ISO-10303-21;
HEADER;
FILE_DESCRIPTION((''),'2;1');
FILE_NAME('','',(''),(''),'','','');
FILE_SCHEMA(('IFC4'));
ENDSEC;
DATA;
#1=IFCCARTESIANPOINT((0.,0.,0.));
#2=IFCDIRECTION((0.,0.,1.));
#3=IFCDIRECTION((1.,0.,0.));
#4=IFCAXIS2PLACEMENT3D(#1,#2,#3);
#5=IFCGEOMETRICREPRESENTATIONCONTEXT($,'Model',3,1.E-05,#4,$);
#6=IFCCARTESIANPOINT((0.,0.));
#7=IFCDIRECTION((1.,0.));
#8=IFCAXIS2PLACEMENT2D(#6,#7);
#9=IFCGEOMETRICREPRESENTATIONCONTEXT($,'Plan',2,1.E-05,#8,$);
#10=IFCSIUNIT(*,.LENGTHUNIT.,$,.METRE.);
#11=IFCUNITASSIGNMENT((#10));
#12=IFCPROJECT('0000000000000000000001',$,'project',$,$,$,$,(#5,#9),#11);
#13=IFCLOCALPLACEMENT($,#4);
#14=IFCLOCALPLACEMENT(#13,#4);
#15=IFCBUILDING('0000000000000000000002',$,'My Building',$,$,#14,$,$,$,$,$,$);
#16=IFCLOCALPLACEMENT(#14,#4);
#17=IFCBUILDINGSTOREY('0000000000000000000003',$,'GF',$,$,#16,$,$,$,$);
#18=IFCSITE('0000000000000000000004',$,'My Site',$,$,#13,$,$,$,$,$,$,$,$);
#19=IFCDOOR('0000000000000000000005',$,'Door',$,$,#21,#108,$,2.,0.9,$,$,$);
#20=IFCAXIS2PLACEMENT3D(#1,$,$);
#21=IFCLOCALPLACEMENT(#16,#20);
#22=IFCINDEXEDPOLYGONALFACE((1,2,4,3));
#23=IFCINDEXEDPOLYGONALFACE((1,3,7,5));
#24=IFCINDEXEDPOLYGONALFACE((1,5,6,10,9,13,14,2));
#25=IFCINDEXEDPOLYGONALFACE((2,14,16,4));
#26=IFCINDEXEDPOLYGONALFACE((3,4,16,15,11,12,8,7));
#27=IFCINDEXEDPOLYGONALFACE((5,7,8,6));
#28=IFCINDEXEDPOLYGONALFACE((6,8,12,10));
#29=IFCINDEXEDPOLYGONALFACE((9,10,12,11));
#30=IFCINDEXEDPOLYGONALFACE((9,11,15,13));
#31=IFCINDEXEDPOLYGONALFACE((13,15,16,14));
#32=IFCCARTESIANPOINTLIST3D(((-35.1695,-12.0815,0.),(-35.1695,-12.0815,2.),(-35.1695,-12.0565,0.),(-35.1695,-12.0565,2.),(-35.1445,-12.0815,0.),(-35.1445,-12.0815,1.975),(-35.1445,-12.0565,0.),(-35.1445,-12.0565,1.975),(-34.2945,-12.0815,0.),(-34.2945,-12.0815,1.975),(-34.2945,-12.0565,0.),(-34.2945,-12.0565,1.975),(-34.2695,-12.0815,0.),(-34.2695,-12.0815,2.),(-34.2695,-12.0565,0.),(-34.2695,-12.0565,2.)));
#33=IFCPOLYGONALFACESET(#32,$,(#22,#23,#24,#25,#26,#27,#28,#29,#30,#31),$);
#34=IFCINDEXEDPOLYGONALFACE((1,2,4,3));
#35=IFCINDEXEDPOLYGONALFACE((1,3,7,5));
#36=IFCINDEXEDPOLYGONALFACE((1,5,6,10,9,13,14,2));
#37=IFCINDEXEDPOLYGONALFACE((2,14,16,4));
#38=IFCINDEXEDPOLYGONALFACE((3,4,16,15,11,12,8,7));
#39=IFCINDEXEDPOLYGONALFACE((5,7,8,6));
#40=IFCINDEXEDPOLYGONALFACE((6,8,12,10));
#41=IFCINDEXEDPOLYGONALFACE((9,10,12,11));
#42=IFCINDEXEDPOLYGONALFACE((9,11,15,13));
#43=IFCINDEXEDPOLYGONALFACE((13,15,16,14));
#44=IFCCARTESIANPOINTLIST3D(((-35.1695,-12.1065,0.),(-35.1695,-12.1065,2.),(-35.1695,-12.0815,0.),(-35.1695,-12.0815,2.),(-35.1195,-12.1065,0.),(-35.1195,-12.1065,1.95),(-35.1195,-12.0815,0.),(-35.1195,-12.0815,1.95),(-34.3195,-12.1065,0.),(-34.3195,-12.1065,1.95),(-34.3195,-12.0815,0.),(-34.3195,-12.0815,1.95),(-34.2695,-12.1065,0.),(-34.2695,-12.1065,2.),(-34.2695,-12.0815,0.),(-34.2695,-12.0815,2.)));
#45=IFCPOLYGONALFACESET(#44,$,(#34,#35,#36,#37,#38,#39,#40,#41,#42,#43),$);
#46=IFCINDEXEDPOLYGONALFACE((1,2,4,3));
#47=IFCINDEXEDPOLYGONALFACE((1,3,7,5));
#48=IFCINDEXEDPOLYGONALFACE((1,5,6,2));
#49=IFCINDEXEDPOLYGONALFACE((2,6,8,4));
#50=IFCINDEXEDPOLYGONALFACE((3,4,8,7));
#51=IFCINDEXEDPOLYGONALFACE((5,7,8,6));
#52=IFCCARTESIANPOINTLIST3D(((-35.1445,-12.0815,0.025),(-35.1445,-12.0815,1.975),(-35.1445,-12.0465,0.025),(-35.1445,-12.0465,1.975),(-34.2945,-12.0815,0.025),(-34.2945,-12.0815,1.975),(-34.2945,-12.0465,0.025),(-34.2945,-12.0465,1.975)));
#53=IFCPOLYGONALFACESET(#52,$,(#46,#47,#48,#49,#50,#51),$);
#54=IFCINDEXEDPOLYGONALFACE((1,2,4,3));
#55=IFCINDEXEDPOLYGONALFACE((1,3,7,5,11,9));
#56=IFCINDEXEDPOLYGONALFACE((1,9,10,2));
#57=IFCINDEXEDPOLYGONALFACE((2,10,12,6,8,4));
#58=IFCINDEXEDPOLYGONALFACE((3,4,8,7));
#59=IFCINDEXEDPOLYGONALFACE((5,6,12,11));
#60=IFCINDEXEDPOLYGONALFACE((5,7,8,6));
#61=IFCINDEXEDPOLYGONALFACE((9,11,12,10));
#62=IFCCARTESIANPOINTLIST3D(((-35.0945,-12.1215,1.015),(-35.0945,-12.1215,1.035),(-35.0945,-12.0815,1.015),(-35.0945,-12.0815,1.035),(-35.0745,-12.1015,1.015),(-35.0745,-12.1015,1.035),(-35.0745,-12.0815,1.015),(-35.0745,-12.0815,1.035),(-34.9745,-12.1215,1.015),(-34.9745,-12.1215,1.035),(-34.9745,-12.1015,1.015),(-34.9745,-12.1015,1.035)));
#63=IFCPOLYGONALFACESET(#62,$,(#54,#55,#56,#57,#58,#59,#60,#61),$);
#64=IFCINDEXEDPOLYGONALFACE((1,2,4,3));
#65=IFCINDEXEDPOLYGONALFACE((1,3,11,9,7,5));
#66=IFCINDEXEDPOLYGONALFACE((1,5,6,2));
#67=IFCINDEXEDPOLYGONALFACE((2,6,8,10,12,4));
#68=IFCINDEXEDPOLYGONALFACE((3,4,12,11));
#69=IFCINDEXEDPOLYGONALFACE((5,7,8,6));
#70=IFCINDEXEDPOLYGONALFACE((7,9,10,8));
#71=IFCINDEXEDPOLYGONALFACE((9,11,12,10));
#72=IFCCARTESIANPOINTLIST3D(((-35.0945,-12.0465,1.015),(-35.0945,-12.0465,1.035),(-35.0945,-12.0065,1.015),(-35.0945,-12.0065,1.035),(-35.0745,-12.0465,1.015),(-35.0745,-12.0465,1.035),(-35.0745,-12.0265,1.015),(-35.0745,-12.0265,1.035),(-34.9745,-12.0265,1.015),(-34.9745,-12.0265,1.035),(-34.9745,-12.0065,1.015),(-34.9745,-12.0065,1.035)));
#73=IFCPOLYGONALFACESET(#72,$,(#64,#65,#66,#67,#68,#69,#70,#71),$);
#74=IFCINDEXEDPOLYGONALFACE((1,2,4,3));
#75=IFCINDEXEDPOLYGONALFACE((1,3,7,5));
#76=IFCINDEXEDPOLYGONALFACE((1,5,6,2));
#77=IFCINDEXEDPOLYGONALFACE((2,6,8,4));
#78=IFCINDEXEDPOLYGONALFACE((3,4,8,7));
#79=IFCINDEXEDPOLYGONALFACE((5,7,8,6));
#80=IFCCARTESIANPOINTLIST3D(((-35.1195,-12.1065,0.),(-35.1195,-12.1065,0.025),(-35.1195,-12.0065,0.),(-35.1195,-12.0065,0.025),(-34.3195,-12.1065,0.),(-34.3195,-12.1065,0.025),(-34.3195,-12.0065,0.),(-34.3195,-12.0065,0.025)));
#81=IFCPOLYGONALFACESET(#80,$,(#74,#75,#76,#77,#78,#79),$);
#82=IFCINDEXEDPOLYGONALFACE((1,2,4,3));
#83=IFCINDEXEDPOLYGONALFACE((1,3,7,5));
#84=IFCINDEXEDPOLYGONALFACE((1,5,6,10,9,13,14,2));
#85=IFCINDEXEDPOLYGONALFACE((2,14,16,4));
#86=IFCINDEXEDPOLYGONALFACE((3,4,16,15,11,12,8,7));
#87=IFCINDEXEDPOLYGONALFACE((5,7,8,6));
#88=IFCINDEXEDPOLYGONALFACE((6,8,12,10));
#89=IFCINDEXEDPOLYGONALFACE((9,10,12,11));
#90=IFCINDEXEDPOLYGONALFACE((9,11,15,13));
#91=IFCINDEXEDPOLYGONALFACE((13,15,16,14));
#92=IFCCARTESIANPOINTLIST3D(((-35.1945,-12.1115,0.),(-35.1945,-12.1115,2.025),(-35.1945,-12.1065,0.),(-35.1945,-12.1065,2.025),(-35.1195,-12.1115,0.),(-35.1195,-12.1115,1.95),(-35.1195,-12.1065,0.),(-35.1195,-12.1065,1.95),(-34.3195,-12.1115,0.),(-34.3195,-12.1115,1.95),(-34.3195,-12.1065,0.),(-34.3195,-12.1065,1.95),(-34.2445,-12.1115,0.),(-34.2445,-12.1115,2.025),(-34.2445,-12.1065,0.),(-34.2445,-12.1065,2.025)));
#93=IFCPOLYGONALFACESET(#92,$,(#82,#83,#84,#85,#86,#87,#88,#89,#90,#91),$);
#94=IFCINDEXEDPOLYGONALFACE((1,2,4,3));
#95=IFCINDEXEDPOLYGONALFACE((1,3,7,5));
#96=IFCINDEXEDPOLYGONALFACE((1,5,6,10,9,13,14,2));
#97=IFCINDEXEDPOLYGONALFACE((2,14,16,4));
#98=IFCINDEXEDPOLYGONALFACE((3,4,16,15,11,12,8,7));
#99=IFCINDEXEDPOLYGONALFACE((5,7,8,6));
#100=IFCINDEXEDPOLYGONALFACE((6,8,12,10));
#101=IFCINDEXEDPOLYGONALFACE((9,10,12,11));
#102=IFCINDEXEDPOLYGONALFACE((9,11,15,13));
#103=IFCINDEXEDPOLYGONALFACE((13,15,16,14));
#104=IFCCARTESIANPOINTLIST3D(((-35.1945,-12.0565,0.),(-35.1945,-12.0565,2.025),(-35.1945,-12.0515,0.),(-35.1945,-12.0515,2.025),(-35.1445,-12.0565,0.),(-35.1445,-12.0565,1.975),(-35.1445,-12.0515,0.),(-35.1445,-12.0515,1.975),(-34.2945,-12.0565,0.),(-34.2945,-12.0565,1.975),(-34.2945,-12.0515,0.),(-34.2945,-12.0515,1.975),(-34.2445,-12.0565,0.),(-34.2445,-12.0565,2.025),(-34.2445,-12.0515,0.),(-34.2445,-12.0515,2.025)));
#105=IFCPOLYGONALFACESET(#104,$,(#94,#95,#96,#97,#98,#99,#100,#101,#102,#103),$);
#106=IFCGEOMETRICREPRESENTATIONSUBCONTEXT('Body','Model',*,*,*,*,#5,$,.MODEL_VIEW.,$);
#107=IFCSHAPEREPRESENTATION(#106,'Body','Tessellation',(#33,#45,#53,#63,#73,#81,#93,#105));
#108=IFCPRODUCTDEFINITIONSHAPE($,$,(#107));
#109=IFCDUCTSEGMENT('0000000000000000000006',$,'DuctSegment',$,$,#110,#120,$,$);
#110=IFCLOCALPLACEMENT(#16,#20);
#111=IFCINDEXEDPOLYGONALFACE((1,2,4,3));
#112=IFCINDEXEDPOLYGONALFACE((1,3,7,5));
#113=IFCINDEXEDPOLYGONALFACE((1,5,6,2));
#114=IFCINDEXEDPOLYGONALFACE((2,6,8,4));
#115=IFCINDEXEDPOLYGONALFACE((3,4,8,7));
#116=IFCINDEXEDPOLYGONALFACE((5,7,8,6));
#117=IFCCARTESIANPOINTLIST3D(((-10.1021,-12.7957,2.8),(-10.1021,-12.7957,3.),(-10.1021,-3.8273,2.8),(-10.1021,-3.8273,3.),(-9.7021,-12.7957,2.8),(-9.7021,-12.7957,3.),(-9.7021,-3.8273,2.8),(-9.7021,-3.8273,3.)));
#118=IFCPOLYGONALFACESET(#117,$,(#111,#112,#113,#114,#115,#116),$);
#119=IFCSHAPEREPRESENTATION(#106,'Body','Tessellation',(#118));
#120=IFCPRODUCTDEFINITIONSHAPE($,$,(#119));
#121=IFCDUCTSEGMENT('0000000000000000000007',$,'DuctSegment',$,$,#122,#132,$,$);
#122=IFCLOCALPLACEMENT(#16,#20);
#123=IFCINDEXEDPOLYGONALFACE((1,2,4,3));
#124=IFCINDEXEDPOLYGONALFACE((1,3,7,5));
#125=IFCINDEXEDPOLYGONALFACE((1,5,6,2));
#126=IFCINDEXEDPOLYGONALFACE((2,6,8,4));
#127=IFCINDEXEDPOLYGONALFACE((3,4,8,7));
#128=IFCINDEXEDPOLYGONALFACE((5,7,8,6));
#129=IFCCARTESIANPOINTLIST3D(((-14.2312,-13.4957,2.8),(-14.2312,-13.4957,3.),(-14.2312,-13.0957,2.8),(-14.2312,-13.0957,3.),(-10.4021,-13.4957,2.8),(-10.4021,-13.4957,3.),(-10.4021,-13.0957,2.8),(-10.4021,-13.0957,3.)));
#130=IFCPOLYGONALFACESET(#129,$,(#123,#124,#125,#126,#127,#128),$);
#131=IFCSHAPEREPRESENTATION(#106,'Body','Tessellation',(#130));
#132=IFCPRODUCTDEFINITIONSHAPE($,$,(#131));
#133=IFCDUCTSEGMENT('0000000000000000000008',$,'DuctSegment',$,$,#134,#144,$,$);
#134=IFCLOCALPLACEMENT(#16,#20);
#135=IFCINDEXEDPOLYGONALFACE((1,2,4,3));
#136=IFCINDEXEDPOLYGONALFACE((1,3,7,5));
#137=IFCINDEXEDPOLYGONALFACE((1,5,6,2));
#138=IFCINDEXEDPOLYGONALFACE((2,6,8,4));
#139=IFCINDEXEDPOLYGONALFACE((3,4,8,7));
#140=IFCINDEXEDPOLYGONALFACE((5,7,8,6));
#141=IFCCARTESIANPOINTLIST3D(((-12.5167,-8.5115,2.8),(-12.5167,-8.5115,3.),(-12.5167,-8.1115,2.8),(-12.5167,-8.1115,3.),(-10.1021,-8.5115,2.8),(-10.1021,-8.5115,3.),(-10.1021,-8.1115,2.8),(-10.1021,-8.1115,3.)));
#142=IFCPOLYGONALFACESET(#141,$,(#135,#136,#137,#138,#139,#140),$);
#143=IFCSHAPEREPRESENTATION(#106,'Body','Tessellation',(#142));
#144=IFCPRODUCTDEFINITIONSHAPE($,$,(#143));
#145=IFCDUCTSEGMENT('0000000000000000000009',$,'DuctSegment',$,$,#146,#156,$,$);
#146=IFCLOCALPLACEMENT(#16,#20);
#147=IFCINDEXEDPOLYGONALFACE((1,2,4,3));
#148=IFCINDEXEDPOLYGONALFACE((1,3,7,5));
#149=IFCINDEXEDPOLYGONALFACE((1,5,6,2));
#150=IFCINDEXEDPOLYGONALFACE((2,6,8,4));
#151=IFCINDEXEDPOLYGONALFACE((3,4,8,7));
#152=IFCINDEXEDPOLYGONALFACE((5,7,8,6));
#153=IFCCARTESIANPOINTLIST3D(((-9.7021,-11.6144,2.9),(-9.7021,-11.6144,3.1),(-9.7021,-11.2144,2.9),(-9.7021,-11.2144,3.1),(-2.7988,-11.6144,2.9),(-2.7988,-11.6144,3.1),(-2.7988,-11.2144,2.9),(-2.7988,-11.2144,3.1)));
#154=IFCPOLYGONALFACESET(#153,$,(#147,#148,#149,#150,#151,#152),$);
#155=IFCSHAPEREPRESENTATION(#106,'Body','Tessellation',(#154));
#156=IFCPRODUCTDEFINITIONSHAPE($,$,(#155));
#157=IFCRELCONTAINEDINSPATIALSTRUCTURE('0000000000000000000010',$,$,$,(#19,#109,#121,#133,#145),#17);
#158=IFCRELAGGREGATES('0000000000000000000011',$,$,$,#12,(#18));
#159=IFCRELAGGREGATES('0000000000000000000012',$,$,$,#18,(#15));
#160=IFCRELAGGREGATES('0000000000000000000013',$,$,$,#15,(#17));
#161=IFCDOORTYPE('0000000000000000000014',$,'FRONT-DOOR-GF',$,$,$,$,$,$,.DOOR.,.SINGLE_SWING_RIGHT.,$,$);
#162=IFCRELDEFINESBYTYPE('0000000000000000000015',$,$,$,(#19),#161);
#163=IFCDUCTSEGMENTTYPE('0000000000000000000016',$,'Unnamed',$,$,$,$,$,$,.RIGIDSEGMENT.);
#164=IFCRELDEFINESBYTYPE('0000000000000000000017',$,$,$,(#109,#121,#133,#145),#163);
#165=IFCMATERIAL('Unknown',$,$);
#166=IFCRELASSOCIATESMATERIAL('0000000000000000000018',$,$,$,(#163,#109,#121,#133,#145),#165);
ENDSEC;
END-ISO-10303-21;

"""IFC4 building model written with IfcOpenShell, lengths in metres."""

from ifc_helpers import new_model, entity, si_unit, frame, origin_with_axes, origin_2d_with_axis, place, context, subcontext, project, spatial, line, indexed_curve, rectangle, outline, extrude, shape, source, transform, mapped, material, material_profile, profile_set, profile_usage, type_object, type_shapes, element, save


model = new_model("IFC4")

# Units and contexts
model_context = context("Model", 3, precision=1e-05, world=origin_with_axes())
plan_context = context("Plan", 2, precision=1e-05, world=origin_2d_with_axis())
body_context_1 = subcontext(model_context, "Body", "Model", "MODEL_VIEW")
body_context_2 = subcontext(plan_context, "Body", "Plan", "PLAN_VIEW")
ifc_project = project(units=[si_unit("LENGTHUNIT", "METRE")], contexts=[model_context, plan_context])

# Site, building, storey
site_placement = place(None, origin_with_axes())
site = spatial("IfcSite", under=ifc_project, at=site_placement, Name="My Site")
building_placement = place(site_placement, origin_with_axes())
building = spatial("IfcBuilding", under=site, at=building_placement, Name="My Building")
storey_placement = place(building_placement, origin_with_axes())
storey = spatial("IfcBuildingStorey", under=building, at=storey_placement, Name="GF")

# Shared definitions
ifc_material = material(Name="Unknown")

# Shared definitions
door_type_1 = type_object("IfcDoorType", Name="FRONT-DOOR-GF", OperationType="SINGLE_SWING_RIGHT", PredefinedType="DOOR")
shared_shape_1 = source(origin_with_axes(), body_context_1, "Body", "SweptSolid", [
    extrude(outline(indexed_curve([(0.0, 0.0), (0.0, 2.0), (0.9, 2.0), (0.9, 0.0), (0.875, 0.0), (0.875, 1.975), (0.025, 1.975), (0.025, 0.0)], segments=[line(1, 2, 3, 4, 5, 6, 7, 8, 1)])), frame((0.0, 0.025, 0.0), z_axis=(0.0, -1.0, 0.0), x_axis=(1.0, 0.0, 0.0)), (0.0, 0.0, -1.0), 0.025),
    extrude(outline(indexed_curve([(0.0, 0.0), (0.0, 2.0), (0.9, 2.0), (0.9, 0.0), (0.85, 0.0), (0.85, 1.95), (0.05, 1.95), (0.05, 0.0)], segments=[line(1, 2, 3, 4, 5, 6, 7, 8, 1)])), frame((0.0, 0.0, 0.0), z_axis=(0.0, -1.0, 0.0), x_axis=(1.0, 0.0, 0.0)), (0.0, 0.0, -1.0), 0.025),
    extrude(outline(indexed_curve([(0.0, 0.0), (0.85, 0.0), (0.85, 0.035), (0.0, 0.035)], segments=[line(1, 2, 3, 4, 1)])), frame((0.025, 0.025, 0.025), z_axis=(0.0, 0.0, 1.0), x_axis=(1.0, 0.0, 0.0)), (0.0, 0.0, 1.0), 1.95),
    extrude(outline(indexed_curve([(0.0, 0.0), (0.0, -0.04), (0.12, -0.04), (0.12, -0.02), (0.02, -0.02), (0.02, 0.0)], segments=[line(1, 2, 3, 4, 5, 6, 1)])), frame((0.075, 0.025, 1.015), z_axis=(0.0, 0.0, 1.0), x_axis=(1.0, 0.0, 0.0)), (0.0, 0.0, 1.0), 0.02),
    extrude(outline(indexed_curve([(0.0, 0.0), (0.0, 0.04), (0.12, 0.04), (0.12, 0.02), (0.02, 0.02), (0.02, 0.0)], segments=[line(1, 2, 3, 4, 5, 6, 1)])), frame((0.075, 0.06, 1.015), z_axis=(0.0, 0.0, 1.0), x_axis=(1.0, 0.0, 0.0)), (0.0, 0.0, 1.0), 0.02),
    extrude(outline(indexed_curve([(0.0, 0.0), (0.8, 0.0), (0.8, 0.1), (0.0, 0.1)], segments=[line(1, 2, 3, 4, 1)])), frame((0.05, 0.0, 0.0), z_axis=(0.0, 0.0, 1.0), x_axis=(1.0, 0.0, 0.0)), (0.0, 0.0, 1.0), 0.025),
    extrude(outline(indexed_curve([(0.0, 0.0), (0.0, 2.025), (0.95, 2.025), (0.95, 0.0), (0.875, 0.0), (0.875, 1.95), (0.075, 1.95), (0.075, 0.0)], segments=[line(1, 2, 3, 4, 5, 6, 7, 8, 1)])), frame((-0.025, -0.005, 0.0), z_axis=(0.0, -1.0, 0.0), x_axis=(1.0, 0.0, 0.0)), (0.0, 0.0, -1.0), 0.005),
    extrude(outline(indexed_curve([(0.0, 0.0), (0.0, 2.025), (0.95, 2.025), (0.95, 0.0), (0.9, 0.0), (0.9, 1.975), (0.05, 1.975), (0.05, 0.0)], segments=[line(1, 2, 3, 4, 5, 6, 7, 8, 1)])), frame((-0.025, 0.05, 0.0), z_axis=(0.0, -1.0, 0.0), x_axis=(1.0, 0.0, 0.0)), (0.0, 0.0, -1.0), 0.005),
])
shared_shape_2 = source(origin_with_axes(), body_context_2, "Body", "Curve2D", [
    entity("IfcIndexedPolyCurve", entity("IfcCartesianPointList2D", [[0.0, 0.0], [0.0, 0.05], [0.025, 0.05], [0.025, 0.025], [0.05, 0.025], [0.05, 0.0]]), [entity("IfcLineIndex", [1, 2, 3, 4, 5, 6, 1])]),
    entity("IfcIndexedPolyCurve", entity("IfcCartesianPointList2D", [[0.9, 0.0], [0.9, 0.05], [0.875, 0.05], [0.875, 0.025], [0.85, 0.025], [0.85, 0.0]]), [entity("IfcLineIndex", [1, 2, 3, 4, 5, 6, 1])]),
    entity("IfcTrimmedCurve", entity("IfcEllipse", entity("IfcAxis2Placement2D", entity("IfcCartesianPoint", [0.84, 0.05]), entity("IfcDirection", [1.0, 0.0])), 0.815, 0.85), [entity("IfcCartesianPoint", [0.84, 0.9])], [entity("IfcCartesianPoint", [0.025, 0.05])], True, "CARTESIAN"),
    entity("IfcIndexedPolyCurve", entity("IfcCartesianPointList2D", [[0.875, 0.05], [0.84, 0.05], [0.84, 0.9], [0.875, 0.9]]), [entity("IfcLineIndex", [1, 2, 3, 4, 1])]),
])
type_shapes(door_type_1, [shared_shape_1, shared_shape_2])

# Door
door_1_placement = place(storey_placement, frame((-35.1695, -12.1065, 0.0), z_axis=(0.0, 0.0, 1.0), x_axis=(1.0, 0.0, 0.0)))
element("IfcDoor", 1, at=door_1_placement, inside=storey, type_object=door_type_1, Name="Door", OverallHeight=2.0, OverallWidth=0.9, shapes=[
    shape(body_context_1, "Body", "MappedRepresentation", [mapped(shared_shape_1, transform((0.0, 0.0, 0.0), x_axis=(1.0, 0.0, 0.0), y_axis=(0.0, 1.0, 0.0), z_axis=(0.0, 0.0, 1.0), scale=1.0))]),
    shape(body_context_2, "Body", "MappedRepresentation", [mapped(shared_shape_2, transform((0.0, 0.0, 0.0), x_axis=(1.0, 0.0, 0.0), y_axis=(0.0, 1.0, 0.0), z_axis=(0.0, 0.0, 1.0), scale=1.0))]),
])

# Duct segments
ifc_material_profile_1 = material_profile(ifc_material, rectangle(XDim=0.4, YDim=0.2))
ifc_profile_set_1 = profile_set([ifc_material_profile_1])
ifc_profile_usage_1 = profile_usage(ifc_profile_set_1, cardinal=5)
duct_segment_type = type_object("IfcDuctSegmentType", Name="Unnamed", PredefinedType="RIGIDSEGMENT", material=ifc_profile_set_1)
duct_segment_1_placement = place(storey_placement, frame((-9.9021, -3.8273, 2.9), z_axis=(0.0, -1.0, 0.0), x_axis=(1.0, 0.0, 0.0)))
element("IfcDuctSegment", 2, at=duct_segment_1_placement, inside=storey, type_object=duct_segment_type, material=ifc_profile_usage_1, Name="DuctSegment", context=body_context_1, shape_type="SweptSolid", body=[
    extrude(rectangle(XDim=0.4, YDim=0.2), origin_with_axes(), (0.0, 0.0, 1.0), 8.9684),
])
ifc_profile_usage_2 = profile_usage(ifc_profile_set_1, cardinal=5)
duct_segment_2_placement = place(storey_placement, frame((-10.4021, -13.2957, 2.9), z_axis=(-1.0, 0.0, 0.0), x_axis=(0.0, -1.0, 0.0)))
element("IfcDuctSegment", 3, at=duct_segment_2_placement, inside=storey, type_object=duct_segment_type, material=ifc_profile_usage_2, Name="DuctSegment", context=body_context_1, shape_type="SweptSolid", body=[
    extrude(rectangle(XDim=0.4, YDim=0.2), origin_with_axes(), (0.0, 0.0, 1.0), 3.8291),
])
ifc_profile_usage_3 = profile_usage(ifc_profile_set_1, cardinal=5)
duct_segment_3_placement = place(storey_placement, frame((-10.1021, -8.3115, 2.9), z_axis=(-1.0, 0.0, 0.0), x_axis=(0.0, -1.0, 0.0)))
element("IfcDuctSegment", 4, at=duct_segment_3_placement, inside=storey, type_object=duct_segment_type, material=ifc_profile_usage_3, Name="DuctSegment", context=body_context_1, shape_type="SweptSolid", body=[
    extrude(rectangle(XDim=0.4, YDim=0.2), origin_with_axes(), (0.0, 0.0, 1.0), 2.4145),
])
ifc_profile_usage_4 = profile_usage(ifc_profile_set_1, cardinal=5)
duct_segment_4_placement = place(storey_placement, frame((-9.7021, -11.4144, 3.0), z_axis=(1.0, 0.0, 0.000001), x_axis=(0.0, 1.0, 0.0)))
element("IfcDuctSegment", 5, at=duct_segment_4_placement, inside=storey, type_object=duct_segment_type, material=ifc_profile_usage_4, Name="DuctSegment", context=body_context_1, shape_type="SweptSolid", body=[
    extrude(rectangle(XDim=0.4, YDim=0.2), origin_with_axes(), (0.0, 0.0, 1.0), 6.9034),
])

save(model, "model.ifc")
